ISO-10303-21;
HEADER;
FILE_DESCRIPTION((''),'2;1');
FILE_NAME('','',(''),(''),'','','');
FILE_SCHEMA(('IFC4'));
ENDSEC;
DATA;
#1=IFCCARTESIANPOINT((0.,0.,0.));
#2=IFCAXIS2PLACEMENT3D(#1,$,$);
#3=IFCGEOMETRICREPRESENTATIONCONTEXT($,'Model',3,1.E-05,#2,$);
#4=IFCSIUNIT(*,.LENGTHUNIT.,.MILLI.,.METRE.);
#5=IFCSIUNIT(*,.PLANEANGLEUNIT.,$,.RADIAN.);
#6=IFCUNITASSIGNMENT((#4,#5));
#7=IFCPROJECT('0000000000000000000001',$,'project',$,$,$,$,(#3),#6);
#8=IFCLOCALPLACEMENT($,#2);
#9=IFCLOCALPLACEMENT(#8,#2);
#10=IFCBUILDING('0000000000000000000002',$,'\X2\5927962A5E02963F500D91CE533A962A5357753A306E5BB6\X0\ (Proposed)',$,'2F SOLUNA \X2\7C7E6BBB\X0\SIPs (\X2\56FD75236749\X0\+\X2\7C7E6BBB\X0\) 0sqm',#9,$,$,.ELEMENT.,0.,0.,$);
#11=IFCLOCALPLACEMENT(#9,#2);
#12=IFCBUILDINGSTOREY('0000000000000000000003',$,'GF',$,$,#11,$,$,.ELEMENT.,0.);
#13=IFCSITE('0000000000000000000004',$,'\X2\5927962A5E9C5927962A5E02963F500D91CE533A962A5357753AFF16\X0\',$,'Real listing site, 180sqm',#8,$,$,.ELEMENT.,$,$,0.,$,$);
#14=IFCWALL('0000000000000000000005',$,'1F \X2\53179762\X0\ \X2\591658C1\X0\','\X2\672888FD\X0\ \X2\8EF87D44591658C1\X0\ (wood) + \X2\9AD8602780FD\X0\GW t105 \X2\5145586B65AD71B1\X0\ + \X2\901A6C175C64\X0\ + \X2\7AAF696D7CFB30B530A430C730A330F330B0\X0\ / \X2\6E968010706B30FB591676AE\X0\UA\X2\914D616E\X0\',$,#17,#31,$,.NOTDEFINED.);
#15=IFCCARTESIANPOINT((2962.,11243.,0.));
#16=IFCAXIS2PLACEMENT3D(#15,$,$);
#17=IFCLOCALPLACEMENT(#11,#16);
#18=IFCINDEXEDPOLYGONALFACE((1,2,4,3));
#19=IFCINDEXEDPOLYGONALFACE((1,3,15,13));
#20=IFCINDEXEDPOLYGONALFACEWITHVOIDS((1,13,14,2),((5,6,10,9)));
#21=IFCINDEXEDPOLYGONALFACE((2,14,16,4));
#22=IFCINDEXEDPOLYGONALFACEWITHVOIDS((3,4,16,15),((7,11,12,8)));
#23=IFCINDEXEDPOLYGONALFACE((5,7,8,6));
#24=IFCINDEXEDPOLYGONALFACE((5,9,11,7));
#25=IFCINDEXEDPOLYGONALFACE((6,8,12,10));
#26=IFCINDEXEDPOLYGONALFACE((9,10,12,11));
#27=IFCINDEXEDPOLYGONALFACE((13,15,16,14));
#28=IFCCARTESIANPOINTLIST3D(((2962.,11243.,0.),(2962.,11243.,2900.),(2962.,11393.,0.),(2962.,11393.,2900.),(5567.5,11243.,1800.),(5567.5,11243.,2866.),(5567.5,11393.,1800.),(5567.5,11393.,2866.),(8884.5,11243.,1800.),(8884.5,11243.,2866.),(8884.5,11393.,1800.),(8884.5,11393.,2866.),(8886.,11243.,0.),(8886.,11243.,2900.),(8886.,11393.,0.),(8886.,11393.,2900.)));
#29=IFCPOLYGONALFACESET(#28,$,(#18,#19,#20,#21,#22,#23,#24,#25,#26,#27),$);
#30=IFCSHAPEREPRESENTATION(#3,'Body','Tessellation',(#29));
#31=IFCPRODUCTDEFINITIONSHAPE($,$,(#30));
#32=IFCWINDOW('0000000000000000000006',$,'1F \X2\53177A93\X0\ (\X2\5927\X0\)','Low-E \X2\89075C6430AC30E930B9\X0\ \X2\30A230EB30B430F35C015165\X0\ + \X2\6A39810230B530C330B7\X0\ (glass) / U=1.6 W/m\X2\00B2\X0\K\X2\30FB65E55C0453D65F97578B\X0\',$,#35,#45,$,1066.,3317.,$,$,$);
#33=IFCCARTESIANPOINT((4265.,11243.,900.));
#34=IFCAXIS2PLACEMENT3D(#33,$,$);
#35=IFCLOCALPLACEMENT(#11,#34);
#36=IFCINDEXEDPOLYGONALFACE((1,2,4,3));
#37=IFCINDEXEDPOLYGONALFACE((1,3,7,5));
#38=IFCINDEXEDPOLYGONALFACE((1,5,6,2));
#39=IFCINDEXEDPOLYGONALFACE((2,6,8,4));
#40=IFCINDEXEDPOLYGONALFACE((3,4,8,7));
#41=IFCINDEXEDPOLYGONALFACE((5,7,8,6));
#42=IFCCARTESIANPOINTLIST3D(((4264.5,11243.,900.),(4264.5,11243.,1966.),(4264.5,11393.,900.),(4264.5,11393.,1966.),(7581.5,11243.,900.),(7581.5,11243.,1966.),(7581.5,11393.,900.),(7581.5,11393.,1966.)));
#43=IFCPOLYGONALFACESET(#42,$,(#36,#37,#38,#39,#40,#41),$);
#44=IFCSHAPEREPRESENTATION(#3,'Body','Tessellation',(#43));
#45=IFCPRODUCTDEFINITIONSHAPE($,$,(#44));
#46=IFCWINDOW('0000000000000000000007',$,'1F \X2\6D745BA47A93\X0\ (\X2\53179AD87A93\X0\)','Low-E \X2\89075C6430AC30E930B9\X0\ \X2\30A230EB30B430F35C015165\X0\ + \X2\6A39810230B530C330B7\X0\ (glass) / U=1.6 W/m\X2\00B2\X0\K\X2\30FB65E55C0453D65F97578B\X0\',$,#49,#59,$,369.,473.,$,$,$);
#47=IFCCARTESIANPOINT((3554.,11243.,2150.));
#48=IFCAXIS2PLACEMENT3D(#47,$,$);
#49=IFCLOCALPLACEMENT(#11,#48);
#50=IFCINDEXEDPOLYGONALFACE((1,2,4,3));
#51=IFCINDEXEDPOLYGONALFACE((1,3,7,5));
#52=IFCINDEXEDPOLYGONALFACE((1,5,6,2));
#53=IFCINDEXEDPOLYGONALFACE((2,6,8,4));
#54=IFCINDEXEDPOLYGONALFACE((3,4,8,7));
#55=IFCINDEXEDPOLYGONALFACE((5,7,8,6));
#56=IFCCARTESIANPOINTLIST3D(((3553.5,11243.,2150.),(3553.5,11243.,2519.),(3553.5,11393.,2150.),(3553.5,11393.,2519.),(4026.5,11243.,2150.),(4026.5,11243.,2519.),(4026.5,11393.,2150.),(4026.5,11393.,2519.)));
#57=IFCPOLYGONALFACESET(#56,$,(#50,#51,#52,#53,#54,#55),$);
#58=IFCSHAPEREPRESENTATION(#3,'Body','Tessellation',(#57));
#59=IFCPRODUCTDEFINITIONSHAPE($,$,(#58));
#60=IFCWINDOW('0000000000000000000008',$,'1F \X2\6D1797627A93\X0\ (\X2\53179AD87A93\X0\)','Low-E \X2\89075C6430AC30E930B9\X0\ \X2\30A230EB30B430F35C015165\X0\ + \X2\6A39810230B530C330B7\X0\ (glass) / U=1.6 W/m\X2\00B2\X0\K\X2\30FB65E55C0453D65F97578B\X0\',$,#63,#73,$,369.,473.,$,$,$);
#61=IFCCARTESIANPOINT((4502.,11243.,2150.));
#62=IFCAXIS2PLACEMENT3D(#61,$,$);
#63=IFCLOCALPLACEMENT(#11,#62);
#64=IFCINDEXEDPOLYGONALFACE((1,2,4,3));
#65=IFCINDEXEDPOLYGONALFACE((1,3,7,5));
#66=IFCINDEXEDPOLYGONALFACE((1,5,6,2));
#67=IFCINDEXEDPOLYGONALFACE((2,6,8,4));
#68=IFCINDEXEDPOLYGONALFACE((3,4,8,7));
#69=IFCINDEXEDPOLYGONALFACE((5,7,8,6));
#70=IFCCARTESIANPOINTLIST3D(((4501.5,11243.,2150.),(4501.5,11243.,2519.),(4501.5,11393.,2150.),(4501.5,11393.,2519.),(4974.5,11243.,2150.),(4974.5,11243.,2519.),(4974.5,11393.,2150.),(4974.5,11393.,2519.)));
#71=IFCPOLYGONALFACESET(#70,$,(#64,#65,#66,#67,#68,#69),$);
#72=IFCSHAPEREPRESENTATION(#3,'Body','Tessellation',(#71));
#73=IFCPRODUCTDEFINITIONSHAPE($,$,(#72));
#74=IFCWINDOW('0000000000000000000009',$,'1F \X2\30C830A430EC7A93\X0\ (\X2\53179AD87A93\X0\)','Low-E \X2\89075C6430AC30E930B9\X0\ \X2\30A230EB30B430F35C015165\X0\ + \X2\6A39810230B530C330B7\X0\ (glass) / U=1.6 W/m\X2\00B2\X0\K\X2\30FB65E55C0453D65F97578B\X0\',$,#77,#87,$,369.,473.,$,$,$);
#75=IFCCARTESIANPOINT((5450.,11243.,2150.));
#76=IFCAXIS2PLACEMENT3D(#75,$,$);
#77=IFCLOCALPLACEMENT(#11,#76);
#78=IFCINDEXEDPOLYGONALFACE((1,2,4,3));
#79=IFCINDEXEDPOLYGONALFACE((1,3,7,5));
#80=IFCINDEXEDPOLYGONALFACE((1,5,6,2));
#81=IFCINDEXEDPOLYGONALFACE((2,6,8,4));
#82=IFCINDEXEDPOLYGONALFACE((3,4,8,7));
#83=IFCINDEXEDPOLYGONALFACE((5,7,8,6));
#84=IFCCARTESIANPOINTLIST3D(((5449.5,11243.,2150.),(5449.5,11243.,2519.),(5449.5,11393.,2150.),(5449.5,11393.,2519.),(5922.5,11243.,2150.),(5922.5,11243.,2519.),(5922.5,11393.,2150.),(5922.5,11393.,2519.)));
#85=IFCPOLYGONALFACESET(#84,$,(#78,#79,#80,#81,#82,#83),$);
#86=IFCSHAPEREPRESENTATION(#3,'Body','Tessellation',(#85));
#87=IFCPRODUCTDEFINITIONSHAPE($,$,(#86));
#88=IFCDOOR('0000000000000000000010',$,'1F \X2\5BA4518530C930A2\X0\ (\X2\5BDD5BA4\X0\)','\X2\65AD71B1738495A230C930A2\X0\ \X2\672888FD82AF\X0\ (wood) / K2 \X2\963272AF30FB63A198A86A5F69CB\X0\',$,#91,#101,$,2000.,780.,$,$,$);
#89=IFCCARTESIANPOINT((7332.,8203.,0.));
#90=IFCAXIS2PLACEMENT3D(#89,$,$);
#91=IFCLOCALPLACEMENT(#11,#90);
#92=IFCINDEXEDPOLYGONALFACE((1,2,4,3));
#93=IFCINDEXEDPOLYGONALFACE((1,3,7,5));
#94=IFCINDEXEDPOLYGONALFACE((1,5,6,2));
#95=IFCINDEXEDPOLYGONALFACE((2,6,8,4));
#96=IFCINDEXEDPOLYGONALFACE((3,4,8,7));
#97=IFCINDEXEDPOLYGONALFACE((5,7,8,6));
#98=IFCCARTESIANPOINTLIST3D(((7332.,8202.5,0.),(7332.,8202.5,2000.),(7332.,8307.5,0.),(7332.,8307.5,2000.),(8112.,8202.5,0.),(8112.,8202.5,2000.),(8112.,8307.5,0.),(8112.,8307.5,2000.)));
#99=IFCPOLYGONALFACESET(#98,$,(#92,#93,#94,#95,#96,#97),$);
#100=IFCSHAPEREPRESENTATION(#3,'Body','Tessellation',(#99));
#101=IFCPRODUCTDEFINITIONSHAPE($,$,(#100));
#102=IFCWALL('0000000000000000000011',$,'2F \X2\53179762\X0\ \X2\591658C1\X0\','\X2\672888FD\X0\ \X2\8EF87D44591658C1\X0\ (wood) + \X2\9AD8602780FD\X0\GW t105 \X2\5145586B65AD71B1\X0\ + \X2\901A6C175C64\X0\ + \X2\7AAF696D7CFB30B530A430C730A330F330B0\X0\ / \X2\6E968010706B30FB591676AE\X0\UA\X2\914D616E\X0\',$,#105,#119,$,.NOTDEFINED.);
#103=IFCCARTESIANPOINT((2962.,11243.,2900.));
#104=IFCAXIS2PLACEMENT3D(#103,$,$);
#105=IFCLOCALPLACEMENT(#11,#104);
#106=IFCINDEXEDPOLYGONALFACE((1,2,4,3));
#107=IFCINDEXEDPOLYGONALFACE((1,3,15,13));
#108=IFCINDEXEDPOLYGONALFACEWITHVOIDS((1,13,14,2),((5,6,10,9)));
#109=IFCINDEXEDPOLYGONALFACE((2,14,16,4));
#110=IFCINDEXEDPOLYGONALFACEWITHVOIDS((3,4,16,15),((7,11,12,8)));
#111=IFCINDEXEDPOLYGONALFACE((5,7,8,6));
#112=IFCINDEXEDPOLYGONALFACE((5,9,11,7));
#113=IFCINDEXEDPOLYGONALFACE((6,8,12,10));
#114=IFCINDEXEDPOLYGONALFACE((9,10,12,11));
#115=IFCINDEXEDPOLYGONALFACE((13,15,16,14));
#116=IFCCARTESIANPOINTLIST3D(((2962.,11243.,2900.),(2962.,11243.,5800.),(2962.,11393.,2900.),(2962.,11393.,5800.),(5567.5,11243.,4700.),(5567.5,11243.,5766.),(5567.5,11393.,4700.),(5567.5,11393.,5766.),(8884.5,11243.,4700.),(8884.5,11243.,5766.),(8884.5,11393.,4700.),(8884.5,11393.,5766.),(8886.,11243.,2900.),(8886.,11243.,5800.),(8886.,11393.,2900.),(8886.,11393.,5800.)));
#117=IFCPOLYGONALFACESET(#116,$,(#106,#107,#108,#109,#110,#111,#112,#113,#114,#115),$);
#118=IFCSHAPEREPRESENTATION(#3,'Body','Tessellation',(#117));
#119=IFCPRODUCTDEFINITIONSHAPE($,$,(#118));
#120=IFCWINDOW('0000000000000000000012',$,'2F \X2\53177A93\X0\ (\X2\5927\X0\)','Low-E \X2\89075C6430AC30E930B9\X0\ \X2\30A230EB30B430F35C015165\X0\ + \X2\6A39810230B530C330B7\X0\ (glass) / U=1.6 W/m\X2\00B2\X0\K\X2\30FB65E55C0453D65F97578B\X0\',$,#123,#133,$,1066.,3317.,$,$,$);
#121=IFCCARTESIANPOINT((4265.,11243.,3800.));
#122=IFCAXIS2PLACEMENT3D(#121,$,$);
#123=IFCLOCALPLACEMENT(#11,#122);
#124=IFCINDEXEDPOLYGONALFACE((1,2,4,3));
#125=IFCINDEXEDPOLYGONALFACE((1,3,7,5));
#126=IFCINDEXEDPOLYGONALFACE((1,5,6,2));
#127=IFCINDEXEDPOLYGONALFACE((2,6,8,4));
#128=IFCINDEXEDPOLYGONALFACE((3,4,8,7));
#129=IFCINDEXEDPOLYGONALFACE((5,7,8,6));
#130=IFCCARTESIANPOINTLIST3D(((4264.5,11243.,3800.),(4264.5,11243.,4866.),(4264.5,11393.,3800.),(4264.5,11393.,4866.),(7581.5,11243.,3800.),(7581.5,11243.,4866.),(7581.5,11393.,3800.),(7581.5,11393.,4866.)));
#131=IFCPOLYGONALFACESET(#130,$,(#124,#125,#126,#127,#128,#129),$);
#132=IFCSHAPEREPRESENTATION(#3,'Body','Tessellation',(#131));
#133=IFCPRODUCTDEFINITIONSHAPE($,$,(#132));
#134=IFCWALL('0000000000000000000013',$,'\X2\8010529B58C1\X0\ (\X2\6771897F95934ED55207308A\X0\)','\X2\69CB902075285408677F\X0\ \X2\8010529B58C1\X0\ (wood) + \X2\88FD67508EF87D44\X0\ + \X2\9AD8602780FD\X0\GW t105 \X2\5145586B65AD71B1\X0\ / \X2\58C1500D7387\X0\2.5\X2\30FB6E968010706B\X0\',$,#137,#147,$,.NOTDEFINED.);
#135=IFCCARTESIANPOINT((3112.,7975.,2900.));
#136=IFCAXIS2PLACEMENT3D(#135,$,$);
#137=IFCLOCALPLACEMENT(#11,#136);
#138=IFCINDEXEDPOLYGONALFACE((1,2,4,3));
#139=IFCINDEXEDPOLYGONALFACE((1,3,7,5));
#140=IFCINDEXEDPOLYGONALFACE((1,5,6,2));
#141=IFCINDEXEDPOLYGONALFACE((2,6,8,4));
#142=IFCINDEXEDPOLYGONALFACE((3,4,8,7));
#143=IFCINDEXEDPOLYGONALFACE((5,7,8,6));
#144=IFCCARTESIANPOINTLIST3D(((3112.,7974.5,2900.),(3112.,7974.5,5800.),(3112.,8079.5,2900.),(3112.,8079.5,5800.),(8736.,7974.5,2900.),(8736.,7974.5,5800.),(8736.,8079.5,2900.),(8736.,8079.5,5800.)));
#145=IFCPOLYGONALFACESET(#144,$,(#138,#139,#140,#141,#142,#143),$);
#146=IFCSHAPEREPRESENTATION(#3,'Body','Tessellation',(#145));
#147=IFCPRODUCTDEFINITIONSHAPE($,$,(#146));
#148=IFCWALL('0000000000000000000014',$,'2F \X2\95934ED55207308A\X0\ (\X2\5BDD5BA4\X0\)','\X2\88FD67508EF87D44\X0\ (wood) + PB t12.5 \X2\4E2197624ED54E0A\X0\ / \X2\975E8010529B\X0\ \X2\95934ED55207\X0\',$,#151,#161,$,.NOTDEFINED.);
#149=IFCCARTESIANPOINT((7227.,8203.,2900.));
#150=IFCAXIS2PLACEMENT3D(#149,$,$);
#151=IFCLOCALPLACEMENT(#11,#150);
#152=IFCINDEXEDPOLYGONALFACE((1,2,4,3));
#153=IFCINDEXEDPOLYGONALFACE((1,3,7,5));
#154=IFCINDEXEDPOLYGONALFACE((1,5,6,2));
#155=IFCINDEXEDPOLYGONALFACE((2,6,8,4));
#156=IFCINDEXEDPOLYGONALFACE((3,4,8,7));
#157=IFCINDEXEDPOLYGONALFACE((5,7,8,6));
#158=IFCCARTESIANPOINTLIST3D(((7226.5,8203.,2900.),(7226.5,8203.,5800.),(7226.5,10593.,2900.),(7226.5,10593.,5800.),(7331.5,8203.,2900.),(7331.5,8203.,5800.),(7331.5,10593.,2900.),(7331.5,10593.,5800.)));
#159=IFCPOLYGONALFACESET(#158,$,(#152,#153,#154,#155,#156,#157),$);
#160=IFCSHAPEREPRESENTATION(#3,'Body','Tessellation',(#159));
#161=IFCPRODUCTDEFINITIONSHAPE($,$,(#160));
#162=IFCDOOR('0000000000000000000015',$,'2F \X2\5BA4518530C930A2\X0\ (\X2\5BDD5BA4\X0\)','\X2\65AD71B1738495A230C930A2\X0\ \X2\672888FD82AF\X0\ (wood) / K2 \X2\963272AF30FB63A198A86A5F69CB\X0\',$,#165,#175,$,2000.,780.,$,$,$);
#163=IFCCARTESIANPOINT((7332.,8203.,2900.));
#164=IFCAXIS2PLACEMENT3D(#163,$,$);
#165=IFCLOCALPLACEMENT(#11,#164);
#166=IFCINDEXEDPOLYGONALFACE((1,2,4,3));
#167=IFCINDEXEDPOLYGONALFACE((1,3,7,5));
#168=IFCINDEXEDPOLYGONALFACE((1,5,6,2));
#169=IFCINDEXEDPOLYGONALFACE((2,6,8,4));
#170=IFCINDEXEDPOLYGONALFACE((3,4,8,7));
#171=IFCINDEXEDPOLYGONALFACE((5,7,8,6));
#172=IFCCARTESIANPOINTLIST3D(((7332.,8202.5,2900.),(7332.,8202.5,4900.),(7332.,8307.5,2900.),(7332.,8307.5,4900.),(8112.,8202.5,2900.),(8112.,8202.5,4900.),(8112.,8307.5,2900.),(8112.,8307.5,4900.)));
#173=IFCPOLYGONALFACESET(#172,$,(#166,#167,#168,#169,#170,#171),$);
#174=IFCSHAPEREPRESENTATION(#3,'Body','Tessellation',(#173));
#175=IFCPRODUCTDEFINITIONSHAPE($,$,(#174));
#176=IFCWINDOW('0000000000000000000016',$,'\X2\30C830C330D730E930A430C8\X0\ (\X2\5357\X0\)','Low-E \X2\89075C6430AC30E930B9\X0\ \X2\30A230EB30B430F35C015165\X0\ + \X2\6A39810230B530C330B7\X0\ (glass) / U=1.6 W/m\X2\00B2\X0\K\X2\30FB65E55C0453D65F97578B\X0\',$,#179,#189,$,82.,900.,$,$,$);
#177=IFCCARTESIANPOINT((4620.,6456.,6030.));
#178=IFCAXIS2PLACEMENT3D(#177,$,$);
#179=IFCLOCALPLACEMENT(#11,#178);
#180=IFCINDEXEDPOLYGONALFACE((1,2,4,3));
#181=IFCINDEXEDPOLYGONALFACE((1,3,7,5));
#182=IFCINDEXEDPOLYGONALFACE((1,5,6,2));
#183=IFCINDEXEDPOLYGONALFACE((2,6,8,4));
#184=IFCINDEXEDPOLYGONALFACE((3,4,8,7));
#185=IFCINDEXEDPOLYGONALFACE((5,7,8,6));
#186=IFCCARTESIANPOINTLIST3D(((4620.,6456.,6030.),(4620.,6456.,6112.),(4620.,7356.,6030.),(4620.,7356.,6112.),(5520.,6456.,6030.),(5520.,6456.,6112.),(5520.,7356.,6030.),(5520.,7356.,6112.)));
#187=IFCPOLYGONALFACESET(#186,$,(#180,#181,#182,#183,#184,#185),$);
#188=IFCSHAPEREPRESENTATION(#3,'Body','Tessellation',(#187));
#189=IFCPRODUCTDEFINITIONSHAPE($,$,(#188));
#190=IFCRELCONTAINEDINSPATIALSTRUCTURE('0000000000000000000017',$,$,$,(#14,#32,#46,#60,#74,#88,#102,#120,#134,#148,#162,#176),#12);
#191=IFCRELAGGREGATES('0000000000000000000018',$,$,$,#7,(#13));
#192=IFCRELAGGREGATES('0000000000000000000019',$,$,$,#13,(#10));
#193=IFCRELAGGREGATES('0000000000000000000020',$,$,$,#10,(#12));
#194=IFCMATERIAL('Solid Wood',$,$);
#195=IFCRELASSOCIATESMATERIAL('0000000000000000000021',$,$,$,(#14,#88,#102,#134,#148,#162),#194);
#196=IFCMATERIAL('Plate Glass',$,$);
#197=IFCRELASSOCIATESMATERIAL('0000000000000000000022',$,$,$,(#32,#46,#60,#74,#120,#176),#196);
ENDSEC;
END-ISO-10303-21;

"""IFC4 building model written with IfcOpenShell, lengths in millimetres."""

from ifc_helpers import new_model, si_unit, frame, frame_2d, origin, place, context, project, spatial, rectangle, extrude, material, element, fill, save


model = new_model("IFC4")

# Units and contexts
model_context = context("Model", 3, precision=1e-05, world=origin())
ifc_project = project(units=[si_unit("LENGTHUNIT", "METRE", prefix="MILLI"), si_unit("PLANEANGLEUNIT", "RADIAN")], contexts=[model_context])

# Site, building, storey
site_placement = place(None, origin())
site = spatial("IfcSite", under=ifc_project, at=site_placement, Name="大阪府大阪市阿倍野区阪南町６", ObjectType="Real listing site, 180sqm", CompositionType="ELEMENT", RefElevation=0.0)
building_placement = place(site_placement, origin())
building = spatial("IfcBuilding", under=site, at=building_placement, Name="大阪市阿倍野区阪南町の家 (Proposed)", ObjectType="2F SOLUNA 籾殻SIPs (国産杉+籾殻) 0sqm", CompositionType="ELEMENT", ElevationOfRefHeight=0.0, ElevationOfTerrain=0.0)
storey_placement = place(building_placement, origin())
storey = spatial("IfcBuildingStorey", under=building, at=storey_placement, Name="GF", CompositionType="ELEMENT", Elevation=0.0)

# Wall, openings, windows
ifc_material_1 = material(Name="Solid Wood")
wall_1_placement = place(storey_placement, frame((2962.0, 11243.0, 0.0)))
wall_1 = element("IfcWall", 1, at=wall_1_placement, inside=storey, material=ifc_material_1, Name="1F 北面 外壁", Description="木製 軸組外壁 (wood) + 高性能GW t105 充填断熱 + 通気層 + 窯業系サイディング / 準耐火・外皮UA配慮", PredefinedType="NOTDEFINED", context=model_context, shape_type="SweptSolid", body=[
    extrude(rectangle(XDim=5924.0, YDim=150.0, at=frame_2d((2962.0, 75.0))), frame((2962.0, 11243.0, 0.0)), (0.0, 0.0, 1.0), 2900.0),
])
opening_1_placement = place(storey_placement, frame((4265.0, 11243.0, 900.0)))
opening_1 = element("IfcOpeningElement", 2, at=opening_1_placement, cuts=wall_1, PredefinedType="NOTDEFINED", context=model_context, shape_type="SweptSolid", body=[
    extrude(rectangle(XDim=3317.0, YDim=150.0, at=frame_2d((1658.0, 75.0))), frame((4265.0, 11243.0, 900.0)), (0.0, 0.0, 1.0), 1066.0),
])
opening_2_placement = place(storey_placement, frame((3554.0, 11243.0, 2150.0)))
opening_2 = element("IfcOpeningElement", 3, at=opening_2_placement, cuts=wall_1, PredefinedType="NOTDEFINED", context=model_context, shape_type="SweptSolid", body=[
    extrude(rectangle(XDim=473.0, YDim=150.0, at=frame_2d((236.0, 75.0))), frame((3554.0, 11243.0, 2150.0)), (0.0, 0.0, 1.0), 369.0),
])
opening_3_placement = place(storey_placement, frame((4502.0, 11243.0, 2150.0)))
opening_3 = element("IfcOpeningElement", 4, at=opening_3_placement, cuts=wall_1, PredefinedType="NOTDEFINED", context=model_context, shape_type="SweptSolid", body=[
    extrude(rectangle(XDim=473.0, YDim=150.0, at=frame_2d((236.0, 75.0))), frame((4502.0, 11243.0, 2150.0)), (0.0, 0.0, 1.0), 369.0),
])
opening_4_placement = place(storey_placement, frame((5450.0, 11243.0, 2150.0)))
opening_4 = element("IfcOpeningElement", 5, at=opening_4_placement, cuts=wall_1, PredefinedType="NOTDEFINED", context=model_context, shape_type="SweptSolid", body=[
    extrude(rectangle(XDim=473.0, YDim=150.0, at=frame_2d((236.0, 75.0))), frame((5450.0, 11243.0, 2150.0)), (0.0, 0.0, 1.0), 369.0),
])
ifc_material_2 = material(Name="Plate Glass")
window_1_placement = place(storey_placement, frame((4265.0, 11243.0, 900.0)))
window_1 = element("IfcWindow", 6, at=window_1_placement, inside=storey, material=ifc_material_2, Name="1F 北窓 (大)", Description="Low-E 複層ガラス アルゴン封入 + 樹脂サッシ (glass) / U=1.6 W/m²K・日射取得型", OverallHeight=1066.0, OverallWidth=3317.0, context=model_context, shape_type="SweptSolid", body=[
    extrude(rectangle(XDim=3317.0, YDim=150.0, at=frame_2d((1658.0, 75.0))), frame((4265.0, 11243.0, 900.0)), (0.0, 0.0, 1.0), 1066.0),
])
fill(opening_1, window_1)
window_2_placement = place(storey_placement, frame((3554.0, 11243.0, 2150.0)))
window_2 = element("IfcWindow", 7, at=window_2_placement, inside=storey, material=ifc_material_2, Name="1F 浴室窓 (北高窓)", Description="Low-E 複層ガラス アルゴン封入 + 樹脂サッシ (glass) / U=1.6 W/m²K・日射取得型", OverallHeight=369.0, OverallWidth=473.0, context=model_context, shape_type="SweptSolid", body=[
    extrude(rectangle(XDim=473.0, YDim=150.0, at=frame_2d((236.0, 75.0))), frame((3554.0, 11243.0, 2150.0)), (0.0, 0.0, 1.0), 369.0),
])
fill(opening_2, window_2)
window_3_placement = place(storey_placement, frame((4502.0, 11243.0, 2150.0)))
window_3 = element("IfcWindow", 8, at=window_3_placement, inside=storey, material=ifc_material_2, Name="1F 洗面窓 (北高窓)", Description="Low-E 複層ガラス アルゴン封入 + 樹脂サッシ (glass) / U=1.6 W/m²K・日射取得型", OverallHeight=369.0, OverallWidth=473.0, context=model_context, shape_type="SweptSolid", body=[
    extrude(rectangle(XDim=473.0, YDim=150.0, at=frame_2d((236.0, 75.0))), frame((4502.0, 11243.0, 2150.0)), (0.0, 0.0, 1.0), 369.0),
])
fill(opening_3, window_3)
window_4_placement = place(storey_placement, frame((5450.0, 11243.0, 2150.0)))
window_4 = element("IfcWindow", 9, at=window_4_placement, inside=storey, material=ifc_material_2, Name="1F トイレ窓 (北高窓)", Description="Low-E 複層ガラス アルゴン封入 + 樹脂サッシ (glass) / U=1.6 W/m²K・日射取得型", OverallHeight=369.0, OverallWidth=473.0, context=model_context, shape_type="SweptSolid", body=[
    extrude(rectangle(XDim=473.0, YDim=150.0, at=frame_2d((236.0, 75.0))), frame((5450.0, 11243.0, 2150.0)), (0.0, 0.0, 1.0), 369.0),
])
fill(opening_4, window_4)

# Door
door_1_placement = place(storey_placement, frame((7332.0, 8203.0, 0.0)))
element("IfcDoor", 10, at=door_1_placement, inside=storey, material=ifc_material_1, Name="1F 室内ドア (寝室)", Description="断熱玄関ドア 木製芯 (wood) / K2 防犯・採風機構", OverallHeight=2000.0, OverallWidth=780.0, context=model_context, shape_type="SweptSolid", body=[
    extrude(rectangle(XDim=780.0, YDim=105.0, at=frame_2d((390.0, 52.0))), frame((7332.0, 8203.0, 0.0)), (0.0, 0.0, 1.0), 2000.0),
])

# Wall, opening, window
wall_2_placement = place(storey_placement, frame((2962.0, 11243.0, 2900.0)))
wall_2 = element("IfcWall", 11, at=wall_2_placement, inside=storey, material=ifc_material_1, Name="2F 北面 外壁", Description="木製 軸組外壁 (wood) + 高性能GW t105 充填断熱 + 通気層 + 窯業系サイディング / 準耐火・外皮UA配慮", PredefinedType="NOTDEFINED", context=model_context, shape_type="SweptSolid", body=[
    extrude(rectangle(XDim=5924.0, YDim=150.0, at=frame_2d((2962.0, 75.0))), frame((2962.0, 11243.0, 2900.0)), (0.0, 0.0, 1.0), 2900.0),
])
opening_5_placement = place(storey_placement, frame((4265.0, 11243.0, 3800.0)))
opening_5 = element("IfcOpeningElement", 12, at=opening_5_placement, cuts=wall_2, PredefinedType="NOTDEFINED", context=model_context, shape_type="SweptSolid", body=[
    extrude(rectangle(XDim=3317.0, YDim=150.0, at=frame_2d((1658.0, 75.0))), frame((4265.0, 11243.0, 3800.0)), (0.0, 0.0, 1.0), 1066.0),
])
window_5_placement = place(storey_placement, frame((4265.0, 11243.0, 3800.0)))
window_5 = element("IfcWindow", 13, at=window_5_placement, inside=storey, material=ifc_material_2, Name="2F 北窓 (大)", Description="Low-E 複層ガラス アルゴン封入 + 樹脂サッシ (glass) / U=1.6 W/m²K・日射取得型", OverallHeight=1066.0, OverallWidth=3317.0, context=model_context, shape_type="SweptSolid", body=[
    extrude(rectangle(XDim=3317.0, YDim=150.0, at=frame_2d((1658.0, 75.0))), frame((4265.0, 11243.0, 3800.0)), (0.0, 0.0, 1.0), 1066.0),
])
fill(opening_5, window_5)

# Walls
wall_3_placement = place(storey_placement, frame((3112.0, 7975.0, 2900.0)))
element("IfcWall", 14, at=wall_3_placement, inside=storey, material=ifc_material_1, Name="耐力壁 (東西間仕切り)", Description="構造用合板 耐力壁 (wood) + 製材軸組 + 高性能GW t105 充填断熱 / 壁倍率2.5・準耐火", PredefinedType="NOTDEFINED", context=model_context, shape_type="SweptSolid", body=[
    extrude(rectangle(XDim=5624.0, YDim=105.0, at=frame_2d((2812.0, 52.0))), frame((3112.0, 7975.0, 2900.0)), (0.0, 0.0, 1.0), 2900.0),
])
wall_4_placement = place(storey_placement, frame((7227.0, 8203.0, 2900.0)))
element("IfcWall", 15, at=wall_4_placement, inside=storey, material=ifc_material_1, Name="2F 間仕切り (寝室)", Description="製材軸組 (wood) + PB t12.5 両面仕上 / 非耐力 間仕切", PredefinedType="NOTDEFINED", context=model_context, shape_type="SweptSolid", body=[
    extrude(rectangle(XDim=105.0, YDim=2390.0, at=frame_2d((52.0, 1195.0))), frame((7227.0, 8203.0, 2900.0)), (0.0, 0.0, 1.0), 2900.0),
])

# Door
door_2_placement = place(storey_placement, frame((7332.0, 8203.0, 2900.0)))
element("IfcDoor", 16, at=door_2_placement, inside=storey, material=ifc_material_1, Name="2F 室内ドア (寝室)", Description="断熱玄関ドア 木製芯 (wood) / K2 防犯・採風機構", OverallHeight=2000.0, OverallWidth=780.0, context=model_context, shape_type="SweptSolid", body=[
    extrude(rectangle(XDim=780.0, YDim=105.0, at=frame_2d((390.0, 52.0))), frame((7332.0, 8203.0, 2900.0)), (0.0, 0.0, 1.0), 2000.0),
])

# Window
window_6_placement = place(storey_placement, frame((4620.0, 6456.0, 6030.0)))
element("IfcWindow", 17, at=window_6_placement, inside=storey, material=ifc_material_2, Name="トップライト (南)", Description="Low-E 複層ガラス アルゴン封入 + 樹脂サッシ (glass) / U=1.6 W/m²K・日射取得型", OverallHeight=82.0, OverallWidth=900.0, context=model_context, shape_type="SweptSolid", body=[
    extrude(rectangle(XDim=900.0, YDim=900.0, at=frame_2d((450.0, 450.0))), frame((4620.0, 6456.0, 6030.0)), (0.0, 0.0, 1.0), 82.0),
])

save(model, "model.ifc")
